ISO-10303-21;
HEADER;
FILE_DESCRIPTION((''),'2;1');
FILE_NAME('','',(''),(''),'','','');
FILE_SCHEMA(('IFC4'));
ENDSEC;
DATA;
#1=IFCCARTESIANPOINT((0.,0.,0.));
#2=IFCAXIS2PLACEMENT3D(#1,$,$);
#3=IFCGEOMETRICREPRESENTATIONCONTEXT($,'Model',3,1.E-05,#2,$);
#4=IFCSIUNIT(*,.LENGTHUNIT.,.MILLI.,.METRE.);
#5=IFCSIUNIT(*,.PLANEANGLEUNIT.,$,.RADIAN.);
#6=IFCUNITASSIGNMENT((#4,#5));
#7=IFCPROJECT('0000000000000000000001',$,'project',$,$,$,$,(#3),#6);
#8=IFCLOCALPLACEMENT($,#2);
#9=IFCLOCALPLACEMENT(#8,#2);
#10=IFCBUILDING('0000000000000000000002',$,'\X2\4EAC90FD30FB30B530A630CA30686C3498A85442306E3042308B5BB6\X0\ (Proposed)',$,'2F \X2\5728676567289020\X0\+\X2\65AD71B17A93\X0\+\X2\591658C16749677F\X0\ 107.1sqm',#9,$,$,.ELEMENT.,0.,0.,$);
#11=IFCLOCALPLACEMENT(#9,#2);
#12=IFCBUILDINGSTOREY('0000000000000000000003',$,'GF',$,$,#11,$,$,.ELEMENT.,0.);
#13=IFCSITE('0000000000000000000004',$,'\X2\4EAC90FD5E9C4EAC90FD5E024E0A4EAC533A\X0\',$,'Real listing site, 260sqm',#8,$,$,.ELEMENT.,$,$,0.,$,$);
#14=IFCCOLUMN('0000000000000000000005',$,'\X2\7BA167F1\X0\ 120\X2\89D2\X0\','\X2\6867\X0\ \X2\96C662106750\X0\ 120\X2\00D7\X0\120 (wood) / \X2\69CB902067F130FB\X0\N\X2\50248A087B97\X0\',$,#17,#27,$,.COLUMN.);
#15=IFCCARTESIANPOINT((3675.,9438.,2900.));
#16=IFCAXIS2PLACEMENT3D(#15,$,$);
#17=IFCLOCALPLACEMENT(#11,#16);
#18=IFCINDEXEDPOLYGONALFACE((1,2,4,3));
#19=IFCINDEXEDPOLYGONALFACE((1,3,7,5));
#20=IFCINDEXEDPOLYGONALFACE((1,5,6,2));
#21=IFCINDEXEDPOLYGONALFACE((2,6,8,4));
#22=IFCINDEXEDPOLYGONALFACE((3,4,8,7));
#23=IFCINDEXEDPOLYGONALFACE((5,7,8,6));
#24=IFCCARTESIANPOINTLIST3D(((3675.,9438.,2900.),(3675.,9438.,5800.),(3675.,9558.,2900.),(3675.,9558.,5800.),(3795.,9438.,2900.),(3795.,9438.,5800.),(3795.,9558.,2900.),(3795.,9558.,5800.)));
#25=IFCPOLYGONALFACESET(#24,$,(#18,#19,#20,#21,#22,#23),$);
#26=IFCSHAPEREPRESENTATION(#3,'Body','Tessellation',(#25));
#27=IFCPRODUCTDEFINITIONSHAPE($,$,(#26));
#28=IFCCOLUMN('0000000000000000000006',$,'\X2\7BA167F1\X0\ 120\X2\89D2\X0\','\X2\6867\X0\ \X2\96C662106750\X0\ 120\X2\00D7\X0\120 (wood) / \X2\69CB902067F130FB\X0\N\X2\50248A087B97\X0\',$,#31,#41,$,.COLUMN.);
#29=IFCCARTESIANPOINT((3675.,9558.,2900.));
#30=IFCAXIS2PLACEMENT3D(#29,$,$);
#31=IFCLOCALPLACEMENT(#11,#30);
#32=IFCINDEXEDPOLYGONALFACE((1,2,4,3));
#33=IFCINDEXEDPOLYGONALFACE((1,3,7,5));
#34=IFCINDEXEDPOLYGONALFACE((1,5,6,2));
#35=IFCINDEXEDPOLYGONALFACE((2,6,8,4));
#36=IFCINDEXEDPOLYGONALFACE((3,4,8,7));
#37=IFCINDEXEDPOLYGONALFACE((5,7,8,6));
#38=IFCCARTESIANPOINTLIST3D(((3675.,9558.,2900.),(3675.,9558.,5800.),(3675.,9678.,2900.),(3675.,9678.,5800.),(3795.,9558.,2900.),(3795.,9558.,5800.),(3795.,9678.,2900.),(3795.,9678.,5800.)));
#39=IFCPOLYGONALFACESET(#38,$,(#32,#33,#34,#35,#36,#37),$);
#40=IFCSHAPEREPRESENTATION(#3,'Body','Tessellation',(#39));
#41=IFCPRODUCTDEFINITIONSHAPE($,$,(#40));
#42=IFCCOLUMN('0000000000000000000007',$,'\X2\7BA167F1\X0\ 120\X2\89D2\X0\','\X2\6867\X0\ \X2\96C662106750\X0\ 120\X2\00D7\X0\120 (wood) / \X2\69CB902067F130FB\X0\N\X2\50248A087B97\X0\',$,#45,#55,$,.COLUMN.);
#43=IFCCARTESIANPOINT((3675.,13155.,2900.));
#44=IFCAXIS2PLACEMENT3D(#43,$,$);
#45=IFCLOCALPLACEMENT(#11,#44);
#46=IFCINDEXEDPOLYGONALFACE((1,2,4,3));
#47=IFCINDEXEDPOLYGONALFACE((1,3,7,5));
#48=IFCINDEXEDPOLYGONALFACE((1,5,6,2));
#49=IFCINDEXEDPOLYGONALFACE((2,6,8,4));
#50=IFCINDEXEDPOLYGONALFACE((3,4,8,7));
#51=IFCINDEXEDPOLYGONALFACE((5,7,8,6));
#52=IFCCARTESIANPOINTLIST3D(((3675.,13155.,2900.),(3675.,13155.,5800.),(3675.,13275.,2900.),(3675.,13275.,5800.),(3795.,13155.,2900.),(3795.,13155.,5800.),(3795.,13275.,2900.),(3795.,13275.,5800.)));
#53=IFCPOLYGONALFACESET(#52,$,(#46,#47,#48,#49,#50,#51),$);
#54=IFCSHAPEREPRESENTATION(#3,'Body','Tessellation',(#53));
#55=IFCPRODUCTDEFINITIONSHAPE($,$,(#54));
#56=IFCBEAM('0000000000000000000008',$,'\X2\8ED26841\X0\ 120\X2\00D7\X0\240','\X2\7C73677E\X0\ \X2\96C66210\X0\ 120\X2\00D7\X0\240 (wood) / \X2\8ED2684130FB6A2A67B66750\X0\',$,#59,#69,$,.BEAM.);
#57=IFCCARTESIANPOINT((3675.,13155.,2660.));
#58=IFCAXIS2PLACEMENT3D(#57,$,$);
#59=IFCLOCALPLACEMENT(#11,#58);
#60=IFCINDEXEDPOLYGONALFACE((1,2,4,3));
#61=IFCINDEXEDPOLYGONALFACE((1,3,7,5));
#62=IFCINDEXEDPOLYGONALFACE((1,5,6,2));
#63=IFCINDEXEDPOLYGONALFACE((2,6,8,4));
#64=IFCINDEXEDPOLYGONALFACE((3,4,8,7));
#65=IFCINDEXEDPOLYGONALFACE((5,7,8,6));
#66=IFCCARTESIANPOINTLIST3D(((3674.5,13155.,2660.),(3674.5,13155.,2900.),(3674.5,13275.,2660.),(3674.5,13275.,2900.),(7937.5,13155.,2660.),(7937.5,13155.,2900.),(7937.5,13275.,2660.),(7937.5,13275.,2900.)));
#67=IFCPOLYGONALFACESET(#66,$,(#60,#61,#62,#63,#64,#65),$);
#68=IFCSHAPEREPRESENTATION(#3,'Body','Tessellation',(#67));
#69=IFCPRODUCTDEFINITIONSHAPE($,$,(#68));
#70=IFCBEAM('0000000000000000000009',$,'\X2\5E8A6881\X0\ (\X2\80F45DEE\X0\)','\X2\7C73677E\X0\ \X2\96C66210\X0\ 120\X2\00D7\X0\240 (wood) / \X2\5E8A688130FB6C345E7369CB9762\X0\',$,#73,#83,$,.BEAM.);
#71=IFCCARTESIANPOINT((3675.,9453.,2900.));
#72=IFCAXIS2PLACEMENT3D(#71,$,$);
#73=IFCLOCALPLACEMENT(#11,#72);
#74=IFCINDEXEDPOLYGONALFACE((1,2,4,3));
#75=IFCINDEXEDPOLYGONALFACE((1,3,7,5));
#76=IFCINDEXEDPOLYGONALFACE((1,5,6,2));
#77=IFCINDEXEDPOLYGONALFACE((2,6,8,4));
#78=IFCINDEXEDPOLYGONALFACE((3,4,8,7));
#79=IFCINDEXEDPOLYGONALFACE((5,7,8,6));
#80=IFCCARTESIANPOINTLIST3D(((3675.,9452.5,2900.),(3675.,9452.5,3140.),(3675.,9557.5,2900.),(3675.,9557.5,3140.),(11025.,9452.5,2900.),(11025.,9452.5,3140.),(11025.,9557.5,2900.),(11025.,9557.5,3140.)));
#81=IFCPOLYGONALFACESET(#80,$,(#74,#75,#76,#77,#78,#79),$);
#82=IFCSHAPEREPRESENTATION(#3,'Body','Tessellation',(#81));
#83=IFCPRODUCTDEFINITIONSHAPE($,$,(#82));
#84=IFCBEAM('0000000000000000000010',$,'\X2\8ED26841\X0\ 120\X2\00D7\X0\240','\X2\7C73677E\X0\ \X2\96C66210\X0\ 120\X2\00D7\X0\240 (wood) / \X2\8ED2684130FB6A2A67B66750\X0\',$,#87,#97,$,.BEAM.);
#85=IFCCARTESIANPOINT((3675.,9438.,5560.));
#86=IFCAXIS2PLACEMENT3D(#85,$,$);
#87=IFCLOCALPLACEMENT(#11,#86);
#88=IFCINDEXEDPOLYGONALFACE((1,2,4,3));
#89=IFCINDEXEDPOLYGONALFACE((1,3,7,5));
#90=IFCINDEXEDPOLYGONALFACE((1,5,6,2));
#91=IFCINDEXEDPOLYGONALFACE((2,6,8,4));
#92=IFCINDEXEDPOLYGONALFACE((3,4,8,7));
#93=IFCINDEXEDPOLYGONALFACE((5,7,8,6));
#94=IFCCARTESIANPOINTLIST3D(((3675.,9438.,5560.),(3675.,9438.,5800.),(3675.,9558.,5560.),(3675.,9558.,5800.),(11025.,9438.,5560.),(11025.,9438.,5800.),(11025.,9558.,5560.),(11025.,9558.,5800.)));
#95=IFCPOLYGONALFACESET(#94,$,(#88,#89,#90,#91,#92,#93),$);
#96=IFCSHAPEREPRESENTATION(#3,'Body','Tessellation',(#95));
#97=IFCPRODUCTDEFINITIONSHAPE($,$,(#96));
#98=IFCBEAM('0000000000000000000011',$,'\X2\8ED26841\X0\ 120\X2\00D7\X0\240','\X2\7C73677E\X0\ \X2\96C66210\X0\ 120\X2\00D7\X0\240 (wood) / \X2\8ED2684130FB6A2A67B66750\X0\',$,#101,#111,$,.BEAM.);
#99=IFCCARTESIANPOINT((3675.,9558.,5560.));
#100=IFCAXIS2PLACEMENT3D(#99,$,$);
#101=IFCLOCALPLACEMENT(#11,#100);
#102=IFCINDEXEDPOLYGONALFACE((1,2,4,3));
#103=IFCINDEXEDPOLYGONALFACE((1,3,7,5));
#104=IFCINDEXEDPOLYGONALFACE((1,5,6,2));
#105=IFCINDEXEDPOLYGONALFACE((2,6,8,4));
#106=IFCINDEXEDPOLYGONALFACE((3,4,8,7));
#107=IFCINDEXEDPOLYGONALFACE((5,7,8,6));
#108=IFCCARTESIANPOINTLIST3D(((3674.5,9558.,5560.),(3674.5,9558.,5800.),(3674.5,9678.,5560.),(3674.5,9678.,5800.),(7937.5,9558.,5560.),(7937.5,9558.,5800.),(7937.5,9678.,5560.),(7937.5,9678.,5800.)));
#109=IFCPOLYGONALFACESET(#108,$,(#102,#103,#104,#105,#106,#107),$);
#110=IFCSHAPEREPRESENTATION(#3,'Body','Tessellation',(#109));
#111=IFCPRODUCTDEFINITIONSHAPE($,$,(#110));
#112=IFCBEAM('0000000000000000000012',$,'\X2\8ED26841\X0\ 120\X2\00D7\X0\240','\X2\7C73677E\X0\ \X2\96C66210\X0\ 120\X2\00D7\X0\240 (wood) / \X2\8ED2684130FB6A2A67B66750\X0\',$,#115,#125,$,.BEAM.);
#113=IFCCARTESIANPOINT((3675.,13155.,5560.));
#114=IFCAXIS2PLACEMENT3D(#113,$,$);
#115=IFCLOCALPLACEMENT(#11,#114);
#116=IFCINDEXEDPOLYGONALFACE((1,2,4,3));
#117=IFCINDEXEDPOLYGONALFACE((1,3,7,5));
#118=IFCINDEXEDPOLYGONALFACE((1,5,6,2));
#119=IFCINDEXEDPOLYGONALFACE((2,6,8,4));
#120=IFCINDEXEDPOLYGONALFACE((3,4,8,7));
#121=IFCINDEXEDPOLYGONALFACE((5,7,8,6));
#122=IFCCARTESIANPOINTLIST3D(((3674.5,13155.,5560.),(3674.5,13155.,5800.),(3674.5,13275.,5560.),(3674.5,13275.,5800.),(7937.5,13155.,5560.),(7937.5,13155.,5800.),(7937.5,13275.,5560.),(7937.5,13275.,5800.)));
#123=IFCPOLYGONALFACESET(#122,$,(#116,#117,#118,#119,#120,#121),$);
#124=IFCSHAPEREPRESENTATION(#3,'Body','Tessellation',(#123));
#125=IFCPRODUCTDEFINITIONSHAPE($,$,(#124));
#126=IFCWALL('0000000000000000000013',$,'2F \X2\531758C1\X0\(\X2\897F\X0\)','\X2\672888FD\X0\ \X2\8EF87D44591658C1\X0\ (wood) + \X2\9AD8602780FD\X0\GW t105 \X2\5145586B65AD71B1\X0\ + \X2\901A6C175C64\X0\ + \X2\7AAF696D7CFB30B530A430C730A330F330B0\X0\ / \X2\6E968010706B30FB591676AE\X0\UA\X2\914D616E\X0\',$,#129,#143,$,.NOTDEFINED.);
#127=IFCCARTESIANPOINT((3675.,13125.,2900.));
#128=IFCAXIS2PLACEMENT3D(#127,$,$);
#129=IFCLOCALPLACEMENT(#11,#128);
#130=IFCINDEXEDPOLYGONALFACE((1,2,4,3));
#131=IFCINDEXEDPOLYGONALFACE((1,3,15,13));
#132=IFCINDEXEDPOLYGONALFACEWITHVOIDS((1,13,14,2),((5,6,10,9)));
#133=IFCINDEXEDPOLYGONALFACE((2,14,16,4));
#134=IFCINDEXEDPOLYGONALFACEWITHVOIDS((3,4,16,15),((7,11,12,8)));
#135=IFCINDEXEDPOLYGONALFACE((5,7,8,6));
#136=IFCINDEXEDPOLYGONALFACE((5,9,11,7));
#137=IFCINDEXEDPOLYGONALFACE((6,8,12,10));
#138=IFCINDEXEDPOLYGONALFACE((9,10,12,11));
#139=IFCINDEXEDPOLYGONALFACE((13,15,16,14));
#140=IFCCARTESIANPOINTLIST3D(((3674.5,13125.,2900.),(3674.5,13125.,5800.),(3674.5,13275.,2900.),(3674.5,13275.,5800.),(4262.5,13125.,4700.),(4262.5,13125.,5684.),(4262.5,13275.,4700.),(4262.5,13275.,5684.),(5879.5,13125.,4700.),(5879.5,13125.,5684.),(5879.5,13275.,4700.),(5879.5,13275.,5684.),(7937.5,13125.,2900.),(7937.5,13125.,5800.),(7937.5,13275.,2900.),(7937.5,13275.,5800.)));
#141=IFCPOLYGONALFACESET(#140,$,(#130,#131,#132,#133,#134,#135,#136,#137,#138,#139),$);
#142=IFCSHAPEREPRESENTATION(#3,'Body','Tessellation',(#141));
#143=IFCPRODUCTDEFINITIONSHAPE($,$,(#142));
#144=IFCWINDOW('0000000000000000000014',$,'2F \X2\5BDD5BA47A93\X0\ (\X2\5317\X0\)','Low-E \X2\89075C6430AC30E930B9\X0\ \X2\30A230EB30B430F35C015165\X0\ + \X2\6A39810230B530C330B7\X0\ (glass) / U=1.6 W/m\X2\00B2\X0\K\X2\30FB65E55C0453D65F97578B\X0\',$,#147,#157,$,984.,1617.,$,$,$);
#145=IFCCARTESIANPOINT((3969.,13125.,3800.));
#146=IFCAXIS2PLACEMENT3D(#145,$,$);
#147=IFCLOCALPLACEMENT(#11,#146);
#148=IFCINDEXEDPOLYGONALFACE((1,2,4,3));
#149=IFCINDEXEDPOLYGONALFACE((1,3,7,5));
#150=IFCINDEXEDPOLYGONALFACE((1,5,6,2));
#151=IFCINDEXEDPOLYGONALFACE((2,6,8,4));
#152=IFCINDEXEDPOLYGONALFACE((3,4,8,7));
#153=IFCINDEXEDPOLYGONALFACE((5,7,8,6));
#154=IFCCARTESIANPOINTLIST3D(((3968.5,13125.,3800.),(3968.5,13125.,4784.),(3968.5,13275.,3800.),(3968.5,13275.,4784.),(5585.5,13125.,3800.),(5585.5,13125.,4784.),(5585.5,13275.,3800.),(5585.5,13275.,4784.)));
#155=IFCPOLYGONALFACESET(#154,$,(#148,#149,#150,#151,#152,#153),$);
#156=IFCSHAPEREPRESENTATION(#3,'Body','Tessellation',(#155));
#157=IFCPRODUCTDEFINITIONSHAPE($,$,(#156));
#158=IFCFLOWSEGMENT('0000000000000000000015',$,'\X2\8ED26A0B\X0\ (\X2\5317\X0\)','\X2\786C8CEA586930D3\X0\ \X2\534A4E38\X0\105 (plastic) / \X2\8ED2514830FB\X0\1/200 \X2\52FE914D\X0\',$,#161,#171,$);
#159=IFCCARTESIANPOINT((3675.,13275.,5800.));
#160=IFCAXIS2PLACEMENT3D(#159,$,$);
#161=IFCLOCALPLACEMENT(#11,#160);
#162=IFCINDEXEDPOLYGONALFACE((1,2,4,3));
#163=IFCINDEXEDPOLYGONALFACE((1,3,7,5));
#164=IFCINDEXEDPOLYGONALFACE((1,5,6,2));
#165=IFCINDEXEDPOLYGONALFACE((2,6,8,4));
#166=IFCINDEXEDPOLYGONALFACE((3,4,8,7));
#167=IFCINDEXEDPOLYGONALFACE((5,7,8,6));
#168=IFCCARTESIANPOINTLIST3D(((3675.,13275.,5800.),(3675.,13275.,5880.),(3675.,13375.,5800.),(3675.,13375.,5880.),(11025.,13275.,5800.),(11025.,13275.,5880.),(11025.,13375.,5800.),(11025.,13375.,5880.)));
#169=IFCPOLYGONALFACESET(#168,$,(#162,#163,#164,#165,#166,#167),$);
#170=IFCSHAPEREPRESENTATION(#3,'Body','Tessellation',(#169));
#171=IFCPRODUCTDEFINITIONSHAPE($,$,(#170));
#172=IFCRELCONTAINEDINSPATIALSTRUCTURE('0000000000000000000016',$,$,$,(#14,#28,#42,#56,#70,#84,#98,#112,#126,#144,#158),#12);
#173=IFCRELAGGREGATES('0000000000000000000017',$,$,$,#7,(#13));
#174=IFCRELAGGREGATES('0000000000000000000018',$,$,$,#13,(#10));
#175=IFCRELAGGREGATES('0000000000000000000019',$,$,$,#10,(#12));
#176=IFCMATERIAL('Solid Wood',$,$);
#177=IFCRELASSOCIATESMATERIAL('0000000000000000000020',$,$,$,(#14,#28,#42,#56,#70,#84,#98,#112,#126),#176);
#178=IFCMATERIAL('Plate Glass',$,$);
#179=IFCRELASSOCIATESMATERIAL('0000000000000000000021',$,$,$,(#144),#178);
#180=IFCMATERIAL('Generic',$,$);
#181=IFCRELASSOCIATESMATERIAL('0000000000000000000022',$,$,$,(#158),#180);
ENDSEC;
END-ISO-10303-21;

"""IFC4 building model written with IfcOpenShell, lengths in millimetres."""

from ifc_helpers import new_model, si_unit, frame, frame_2d, origin, place, context, project, spatial, rectangle, extrude, material, element, fill, save


model = new_model("IFC4")

# Units and contexts
model_context = context("Model", 3, precision=1e-05, world=origin())
ifc_project = project(units=[si_unit("LENGTHUNIT", "METRE", prefix="MILLI"), si_unit("PLANEANGLEUNIT", "RADIAN")], contexts=[model_context])

# Site, building, storey
site_placement = place(None, origin())
site = spatial("IfcSite", under=ifc_project, at=site_placement, Name="京都府京都市上京区", ObjectType="Real listing site, 260sqm", CompositionType="ELEMENT", RefElevation=0.0)
building_placement = place(site_placement, origin())
building = spatial("IfcBuilding", under=site, at=building_placement, Name="京都・サウナと水風呂のある家 (Proposed)", ObjectType="2F 在来木造+断熱窓+外壁杉板 107.1sqm", CompositionType="ELEMENT", ElevationOfRefHeight=0.0, ElevationOfTerrain=0.0)
storey_placement = place(building_placement, origin())
storey = spatial("IfcBuildingStorey", under=building, at=storey_placement, Name="GF", CompositionType="ELEMENT", Elevation=0.0)

# Columns
ifc_material_1 = material(Name="Solid Wood")
column_1_placement = place(storey_placement, frame((3675.0, 9438.0, 2900.0)))
element("IfcColumn", 1, at=column_1_placement, inside=storey, material=ifc_material_1, Name="管柱 120角", Description="桧 集成材 120×120 (wood) / 構造柱・N値計算", PredefinedType="COLUMN", context=model_context, shape_type="SweptSolid", body=[
    extrude(rectangle(XDim=120.0, YDim=120.0, at=frame_2d((60.0, 60.0))), frame((3675.0, 9438.0, 2900.0)), (0.0, 0.0, 1.0), 2900.0),
])
column_2_placement = place(storey_placement, frame((3675.0, 9558.0, 2900.0)))
element("IfcColumn", 2, at=column_2_placement, inside=storey, material=ifc_material_1, Name="管柱 120角", Description="桧 集成材 120×120 (wood) / 構造柱・N値計算", PredefinedType="COLUMN", context=model_context, shape_type="SweptSolid", body=[
    extrude(rectangle(XDim=120.0, YDim=120.0, at=frame_2d((60.0, 60.0))), frame((3675.0, 9558.0, 2900.0)), (0.0, 0.0, 1.0), 2900.0),
])
column_3_placement = place(storey_placement, frame((3675.0, 13155.0, 2900.0)))
element("IfcColumn", 3, at=column_3_placement, inside=storey, material=ifc_material_1, Name="管柱 120角", Description="桧 集成材 120×120 (wood) / 構造柱・N値計算", PredefinedType="COLUMN", context=model_context, shape_type="SweptSolid", body=[
    extrude(rectangle(XDim=120.0, YDim=120.0, at=frame_2d((60.0, 60.0))), frame((3675.0, 13155.0, 2900.0)), (0.0, 0.0, 1.0), 2900.0),
])

# Beams
beam_1_placement = place(storey_placement, frame((3675.0, 13155.0, 2660.0)))
element("IfcBeam", 4, at=beam_1_placement, inside=storey, material=ifc_material_1, Name="軒桁 120×240", Description="米松 集成 120×240 (wood) / 軒桁・横架材", PredefinedType="BEAM", context=model_context, shape_type="SweptSolid", body=[
    extrude(rectangle(XDim=4263.0, YDim=120.0, at=frame_2d((2131.0, 60.0))), frame((3675.0, 13155.0, 2660.0)), (0.0, 0.0, 1.0), 240.0),
])
beam_2_placement = place(storey_placement, frame((3675.0, 9453.0, 2900.0)))
element("IfcBeam", 5, at=beam_2_placement, inside=storey, material=ifc_material_1, Name="床梁 (胴差)", Description="米松 集成 120×240 (wood) / 床梁・水平構面", PredefinedType="BEAM", context=model_context, shape_type="SweptSolid", body=[
    extrude(rectangle(XDim=7350.0, YDim=105.0, at=frame_2d((3675.0, 52.0))), frame((3675.0, 9453.0, 2900.0)), (0.0, 0.0, 1.0), 240.0),
])
beam_3_placement = place(storey_placement, frame((3675.0, 9438.0, 5560.0)))
element("IfcBeam", 6, at=beam_3_placement, inside=storey, material=ifc_material_1, Name="軒桁 120×240", Description="米松 集成 120×240 (wood) / 軒桁・横架材", PredefinedType="BEAM", context=model_context, shape_type="SweptSolid", body=[
    extrude(rectangle(XDim=7350.0, YDim=120.0, at=frame_2d((3675.0, 60.0))), frame((3675.0, 9438.0, 5560.0)), (0.0, 0.0, 1.0), 240.0),
])
beam_4_placement = place(storey_placement, frame((3675.0, 9558.0, 5560.0)))
element("IfcBeam", 7, at=beam_4_placement, inside=storey, material=ifc_material_1, Name="軒桁 120×240", Description="米松 集成 120×240 (wood) / 軒桁・横架材", PredefinedType="BEAM", context=model_context, shape_type="SweptSolid", body=[
    extrude(rectangle(XDim=4263.0, YDim=120.0, at=frame_2d((2131.0, 60.0))), frame((3675.0, 9558.0, 5560.0)), (0.0, 0.0, 1.0), 240.0),
])
beam_5_placement = place(storey_placement, frame((3675.0, 13155.0, 5560.0)))
element("IfcBeam", 8, at=beam_5_placement, inside=storey, material=ifc_material_1, Name="軒桁 120×240", Description="米松 集成 120×240 (wood) / 軒桁・横架材", PredefinedType="BEAM", context=model_context, shape_type="SweptSolid", body=[
    extrude(rectangle(XDim=4263.0, YDim=120.0, at=frame_2d((2131.0, 60.0))), frame((3675.0, 13155.0, 5560.0)), (0.0, 0.0, 1.0), 240.0),
])

# Wall, opening, window
wall_1_placement = place(storey_placement, frame((3675.0, 13125.0, 2900.0)))
wall_1 = element("IfcWall", 9, at=wall_1_placement, inside=storey, material=ifc_material_1, Name="2F 北壁(西)", Description="木製 軸組外壁 (wood) + 高性能GW t105 充填断熱 + 通気層 + 窯業系サイディング / 準耐火・外皮UA配慮", PredefinedType="NOTDEFINED", context=model_context, shape_type="SweptSolid", body=[
    extrude(rectangle(XDim=4263.0, YDim=150.0, at=frame_2d((2131.0, 75.0))), frame((3675.0, 13125.0, 2900.0)), (0.0, 0.0, 1.0), 2900.0),
])
opening_placement = place(storey_placement, frame((3969.0, 13125.0, 3800.0)))
opening = element("IfcOpeningElement", 10, at=opening_placement, cuts=wall_1, PredefinedType="NOTDEFINED", context=model_context, shape_type="SweptSolid", body=[
    extrude(rectangle(XDim=1617.0, YDim=150.0, at=frame_2d((808.0, 75.0))), frame((3969.0, 13125.0, 3800.0)), (0.0, 0.0, 1.0), 984.0),
])
ifc_material_2 = material(Name="Plate Glass")
window_placement = place(storey_placement, frame((3969.0, 13125.0, 3800.0)))
window = element("IfcWindow", 11, at=window_placement, inside=storey, material=ifc_material_2, Name="2F 寝室窓 (北)", Description="Low-E 複層ガラス アルゴン封入 + 樹脂サッシ (glass) / U=1.6 W/m²K・日射取得型", OverallHeight=984.0, OverallWidth=1617.0, context=model_context, shape_type="SweptSolid", body=[
    extrude(rectangle(XDim=1617.0, YDim=150.0, at=frame_2d((808.0, 75.0))), frame((3969.0, 13125.0, 3800.0)), (0.0, 0.0, 1.0), 984.0),
])
fill(opening, window)

# Shared definitions
ifc_material_3 = material(Name="Generic")

# Flow segment
flow_segment_placement = place(storey_placement, frame((3675.0, 13275.0, 5800.0)))
element("IfcFlowSegment", 12, at=flow_segment_placement, inside=storey, material=ifc_material_3, Name="軒樋 (北)", Description="硬質塩ビ 半丸105 (plastic) / 軒先・1/200 勾配", context=model_context, shape_type="SweptSolid", body=[
    extrude(rectangle(XDim=7350.0, YDim=100.0, at=frame_2d((3675.0, 50.0))), frame((3675.0, 13275.0, 5800.0)), (0.0, 0.0, 1.0), 80.0),
])

save(model, "model.ifc")
